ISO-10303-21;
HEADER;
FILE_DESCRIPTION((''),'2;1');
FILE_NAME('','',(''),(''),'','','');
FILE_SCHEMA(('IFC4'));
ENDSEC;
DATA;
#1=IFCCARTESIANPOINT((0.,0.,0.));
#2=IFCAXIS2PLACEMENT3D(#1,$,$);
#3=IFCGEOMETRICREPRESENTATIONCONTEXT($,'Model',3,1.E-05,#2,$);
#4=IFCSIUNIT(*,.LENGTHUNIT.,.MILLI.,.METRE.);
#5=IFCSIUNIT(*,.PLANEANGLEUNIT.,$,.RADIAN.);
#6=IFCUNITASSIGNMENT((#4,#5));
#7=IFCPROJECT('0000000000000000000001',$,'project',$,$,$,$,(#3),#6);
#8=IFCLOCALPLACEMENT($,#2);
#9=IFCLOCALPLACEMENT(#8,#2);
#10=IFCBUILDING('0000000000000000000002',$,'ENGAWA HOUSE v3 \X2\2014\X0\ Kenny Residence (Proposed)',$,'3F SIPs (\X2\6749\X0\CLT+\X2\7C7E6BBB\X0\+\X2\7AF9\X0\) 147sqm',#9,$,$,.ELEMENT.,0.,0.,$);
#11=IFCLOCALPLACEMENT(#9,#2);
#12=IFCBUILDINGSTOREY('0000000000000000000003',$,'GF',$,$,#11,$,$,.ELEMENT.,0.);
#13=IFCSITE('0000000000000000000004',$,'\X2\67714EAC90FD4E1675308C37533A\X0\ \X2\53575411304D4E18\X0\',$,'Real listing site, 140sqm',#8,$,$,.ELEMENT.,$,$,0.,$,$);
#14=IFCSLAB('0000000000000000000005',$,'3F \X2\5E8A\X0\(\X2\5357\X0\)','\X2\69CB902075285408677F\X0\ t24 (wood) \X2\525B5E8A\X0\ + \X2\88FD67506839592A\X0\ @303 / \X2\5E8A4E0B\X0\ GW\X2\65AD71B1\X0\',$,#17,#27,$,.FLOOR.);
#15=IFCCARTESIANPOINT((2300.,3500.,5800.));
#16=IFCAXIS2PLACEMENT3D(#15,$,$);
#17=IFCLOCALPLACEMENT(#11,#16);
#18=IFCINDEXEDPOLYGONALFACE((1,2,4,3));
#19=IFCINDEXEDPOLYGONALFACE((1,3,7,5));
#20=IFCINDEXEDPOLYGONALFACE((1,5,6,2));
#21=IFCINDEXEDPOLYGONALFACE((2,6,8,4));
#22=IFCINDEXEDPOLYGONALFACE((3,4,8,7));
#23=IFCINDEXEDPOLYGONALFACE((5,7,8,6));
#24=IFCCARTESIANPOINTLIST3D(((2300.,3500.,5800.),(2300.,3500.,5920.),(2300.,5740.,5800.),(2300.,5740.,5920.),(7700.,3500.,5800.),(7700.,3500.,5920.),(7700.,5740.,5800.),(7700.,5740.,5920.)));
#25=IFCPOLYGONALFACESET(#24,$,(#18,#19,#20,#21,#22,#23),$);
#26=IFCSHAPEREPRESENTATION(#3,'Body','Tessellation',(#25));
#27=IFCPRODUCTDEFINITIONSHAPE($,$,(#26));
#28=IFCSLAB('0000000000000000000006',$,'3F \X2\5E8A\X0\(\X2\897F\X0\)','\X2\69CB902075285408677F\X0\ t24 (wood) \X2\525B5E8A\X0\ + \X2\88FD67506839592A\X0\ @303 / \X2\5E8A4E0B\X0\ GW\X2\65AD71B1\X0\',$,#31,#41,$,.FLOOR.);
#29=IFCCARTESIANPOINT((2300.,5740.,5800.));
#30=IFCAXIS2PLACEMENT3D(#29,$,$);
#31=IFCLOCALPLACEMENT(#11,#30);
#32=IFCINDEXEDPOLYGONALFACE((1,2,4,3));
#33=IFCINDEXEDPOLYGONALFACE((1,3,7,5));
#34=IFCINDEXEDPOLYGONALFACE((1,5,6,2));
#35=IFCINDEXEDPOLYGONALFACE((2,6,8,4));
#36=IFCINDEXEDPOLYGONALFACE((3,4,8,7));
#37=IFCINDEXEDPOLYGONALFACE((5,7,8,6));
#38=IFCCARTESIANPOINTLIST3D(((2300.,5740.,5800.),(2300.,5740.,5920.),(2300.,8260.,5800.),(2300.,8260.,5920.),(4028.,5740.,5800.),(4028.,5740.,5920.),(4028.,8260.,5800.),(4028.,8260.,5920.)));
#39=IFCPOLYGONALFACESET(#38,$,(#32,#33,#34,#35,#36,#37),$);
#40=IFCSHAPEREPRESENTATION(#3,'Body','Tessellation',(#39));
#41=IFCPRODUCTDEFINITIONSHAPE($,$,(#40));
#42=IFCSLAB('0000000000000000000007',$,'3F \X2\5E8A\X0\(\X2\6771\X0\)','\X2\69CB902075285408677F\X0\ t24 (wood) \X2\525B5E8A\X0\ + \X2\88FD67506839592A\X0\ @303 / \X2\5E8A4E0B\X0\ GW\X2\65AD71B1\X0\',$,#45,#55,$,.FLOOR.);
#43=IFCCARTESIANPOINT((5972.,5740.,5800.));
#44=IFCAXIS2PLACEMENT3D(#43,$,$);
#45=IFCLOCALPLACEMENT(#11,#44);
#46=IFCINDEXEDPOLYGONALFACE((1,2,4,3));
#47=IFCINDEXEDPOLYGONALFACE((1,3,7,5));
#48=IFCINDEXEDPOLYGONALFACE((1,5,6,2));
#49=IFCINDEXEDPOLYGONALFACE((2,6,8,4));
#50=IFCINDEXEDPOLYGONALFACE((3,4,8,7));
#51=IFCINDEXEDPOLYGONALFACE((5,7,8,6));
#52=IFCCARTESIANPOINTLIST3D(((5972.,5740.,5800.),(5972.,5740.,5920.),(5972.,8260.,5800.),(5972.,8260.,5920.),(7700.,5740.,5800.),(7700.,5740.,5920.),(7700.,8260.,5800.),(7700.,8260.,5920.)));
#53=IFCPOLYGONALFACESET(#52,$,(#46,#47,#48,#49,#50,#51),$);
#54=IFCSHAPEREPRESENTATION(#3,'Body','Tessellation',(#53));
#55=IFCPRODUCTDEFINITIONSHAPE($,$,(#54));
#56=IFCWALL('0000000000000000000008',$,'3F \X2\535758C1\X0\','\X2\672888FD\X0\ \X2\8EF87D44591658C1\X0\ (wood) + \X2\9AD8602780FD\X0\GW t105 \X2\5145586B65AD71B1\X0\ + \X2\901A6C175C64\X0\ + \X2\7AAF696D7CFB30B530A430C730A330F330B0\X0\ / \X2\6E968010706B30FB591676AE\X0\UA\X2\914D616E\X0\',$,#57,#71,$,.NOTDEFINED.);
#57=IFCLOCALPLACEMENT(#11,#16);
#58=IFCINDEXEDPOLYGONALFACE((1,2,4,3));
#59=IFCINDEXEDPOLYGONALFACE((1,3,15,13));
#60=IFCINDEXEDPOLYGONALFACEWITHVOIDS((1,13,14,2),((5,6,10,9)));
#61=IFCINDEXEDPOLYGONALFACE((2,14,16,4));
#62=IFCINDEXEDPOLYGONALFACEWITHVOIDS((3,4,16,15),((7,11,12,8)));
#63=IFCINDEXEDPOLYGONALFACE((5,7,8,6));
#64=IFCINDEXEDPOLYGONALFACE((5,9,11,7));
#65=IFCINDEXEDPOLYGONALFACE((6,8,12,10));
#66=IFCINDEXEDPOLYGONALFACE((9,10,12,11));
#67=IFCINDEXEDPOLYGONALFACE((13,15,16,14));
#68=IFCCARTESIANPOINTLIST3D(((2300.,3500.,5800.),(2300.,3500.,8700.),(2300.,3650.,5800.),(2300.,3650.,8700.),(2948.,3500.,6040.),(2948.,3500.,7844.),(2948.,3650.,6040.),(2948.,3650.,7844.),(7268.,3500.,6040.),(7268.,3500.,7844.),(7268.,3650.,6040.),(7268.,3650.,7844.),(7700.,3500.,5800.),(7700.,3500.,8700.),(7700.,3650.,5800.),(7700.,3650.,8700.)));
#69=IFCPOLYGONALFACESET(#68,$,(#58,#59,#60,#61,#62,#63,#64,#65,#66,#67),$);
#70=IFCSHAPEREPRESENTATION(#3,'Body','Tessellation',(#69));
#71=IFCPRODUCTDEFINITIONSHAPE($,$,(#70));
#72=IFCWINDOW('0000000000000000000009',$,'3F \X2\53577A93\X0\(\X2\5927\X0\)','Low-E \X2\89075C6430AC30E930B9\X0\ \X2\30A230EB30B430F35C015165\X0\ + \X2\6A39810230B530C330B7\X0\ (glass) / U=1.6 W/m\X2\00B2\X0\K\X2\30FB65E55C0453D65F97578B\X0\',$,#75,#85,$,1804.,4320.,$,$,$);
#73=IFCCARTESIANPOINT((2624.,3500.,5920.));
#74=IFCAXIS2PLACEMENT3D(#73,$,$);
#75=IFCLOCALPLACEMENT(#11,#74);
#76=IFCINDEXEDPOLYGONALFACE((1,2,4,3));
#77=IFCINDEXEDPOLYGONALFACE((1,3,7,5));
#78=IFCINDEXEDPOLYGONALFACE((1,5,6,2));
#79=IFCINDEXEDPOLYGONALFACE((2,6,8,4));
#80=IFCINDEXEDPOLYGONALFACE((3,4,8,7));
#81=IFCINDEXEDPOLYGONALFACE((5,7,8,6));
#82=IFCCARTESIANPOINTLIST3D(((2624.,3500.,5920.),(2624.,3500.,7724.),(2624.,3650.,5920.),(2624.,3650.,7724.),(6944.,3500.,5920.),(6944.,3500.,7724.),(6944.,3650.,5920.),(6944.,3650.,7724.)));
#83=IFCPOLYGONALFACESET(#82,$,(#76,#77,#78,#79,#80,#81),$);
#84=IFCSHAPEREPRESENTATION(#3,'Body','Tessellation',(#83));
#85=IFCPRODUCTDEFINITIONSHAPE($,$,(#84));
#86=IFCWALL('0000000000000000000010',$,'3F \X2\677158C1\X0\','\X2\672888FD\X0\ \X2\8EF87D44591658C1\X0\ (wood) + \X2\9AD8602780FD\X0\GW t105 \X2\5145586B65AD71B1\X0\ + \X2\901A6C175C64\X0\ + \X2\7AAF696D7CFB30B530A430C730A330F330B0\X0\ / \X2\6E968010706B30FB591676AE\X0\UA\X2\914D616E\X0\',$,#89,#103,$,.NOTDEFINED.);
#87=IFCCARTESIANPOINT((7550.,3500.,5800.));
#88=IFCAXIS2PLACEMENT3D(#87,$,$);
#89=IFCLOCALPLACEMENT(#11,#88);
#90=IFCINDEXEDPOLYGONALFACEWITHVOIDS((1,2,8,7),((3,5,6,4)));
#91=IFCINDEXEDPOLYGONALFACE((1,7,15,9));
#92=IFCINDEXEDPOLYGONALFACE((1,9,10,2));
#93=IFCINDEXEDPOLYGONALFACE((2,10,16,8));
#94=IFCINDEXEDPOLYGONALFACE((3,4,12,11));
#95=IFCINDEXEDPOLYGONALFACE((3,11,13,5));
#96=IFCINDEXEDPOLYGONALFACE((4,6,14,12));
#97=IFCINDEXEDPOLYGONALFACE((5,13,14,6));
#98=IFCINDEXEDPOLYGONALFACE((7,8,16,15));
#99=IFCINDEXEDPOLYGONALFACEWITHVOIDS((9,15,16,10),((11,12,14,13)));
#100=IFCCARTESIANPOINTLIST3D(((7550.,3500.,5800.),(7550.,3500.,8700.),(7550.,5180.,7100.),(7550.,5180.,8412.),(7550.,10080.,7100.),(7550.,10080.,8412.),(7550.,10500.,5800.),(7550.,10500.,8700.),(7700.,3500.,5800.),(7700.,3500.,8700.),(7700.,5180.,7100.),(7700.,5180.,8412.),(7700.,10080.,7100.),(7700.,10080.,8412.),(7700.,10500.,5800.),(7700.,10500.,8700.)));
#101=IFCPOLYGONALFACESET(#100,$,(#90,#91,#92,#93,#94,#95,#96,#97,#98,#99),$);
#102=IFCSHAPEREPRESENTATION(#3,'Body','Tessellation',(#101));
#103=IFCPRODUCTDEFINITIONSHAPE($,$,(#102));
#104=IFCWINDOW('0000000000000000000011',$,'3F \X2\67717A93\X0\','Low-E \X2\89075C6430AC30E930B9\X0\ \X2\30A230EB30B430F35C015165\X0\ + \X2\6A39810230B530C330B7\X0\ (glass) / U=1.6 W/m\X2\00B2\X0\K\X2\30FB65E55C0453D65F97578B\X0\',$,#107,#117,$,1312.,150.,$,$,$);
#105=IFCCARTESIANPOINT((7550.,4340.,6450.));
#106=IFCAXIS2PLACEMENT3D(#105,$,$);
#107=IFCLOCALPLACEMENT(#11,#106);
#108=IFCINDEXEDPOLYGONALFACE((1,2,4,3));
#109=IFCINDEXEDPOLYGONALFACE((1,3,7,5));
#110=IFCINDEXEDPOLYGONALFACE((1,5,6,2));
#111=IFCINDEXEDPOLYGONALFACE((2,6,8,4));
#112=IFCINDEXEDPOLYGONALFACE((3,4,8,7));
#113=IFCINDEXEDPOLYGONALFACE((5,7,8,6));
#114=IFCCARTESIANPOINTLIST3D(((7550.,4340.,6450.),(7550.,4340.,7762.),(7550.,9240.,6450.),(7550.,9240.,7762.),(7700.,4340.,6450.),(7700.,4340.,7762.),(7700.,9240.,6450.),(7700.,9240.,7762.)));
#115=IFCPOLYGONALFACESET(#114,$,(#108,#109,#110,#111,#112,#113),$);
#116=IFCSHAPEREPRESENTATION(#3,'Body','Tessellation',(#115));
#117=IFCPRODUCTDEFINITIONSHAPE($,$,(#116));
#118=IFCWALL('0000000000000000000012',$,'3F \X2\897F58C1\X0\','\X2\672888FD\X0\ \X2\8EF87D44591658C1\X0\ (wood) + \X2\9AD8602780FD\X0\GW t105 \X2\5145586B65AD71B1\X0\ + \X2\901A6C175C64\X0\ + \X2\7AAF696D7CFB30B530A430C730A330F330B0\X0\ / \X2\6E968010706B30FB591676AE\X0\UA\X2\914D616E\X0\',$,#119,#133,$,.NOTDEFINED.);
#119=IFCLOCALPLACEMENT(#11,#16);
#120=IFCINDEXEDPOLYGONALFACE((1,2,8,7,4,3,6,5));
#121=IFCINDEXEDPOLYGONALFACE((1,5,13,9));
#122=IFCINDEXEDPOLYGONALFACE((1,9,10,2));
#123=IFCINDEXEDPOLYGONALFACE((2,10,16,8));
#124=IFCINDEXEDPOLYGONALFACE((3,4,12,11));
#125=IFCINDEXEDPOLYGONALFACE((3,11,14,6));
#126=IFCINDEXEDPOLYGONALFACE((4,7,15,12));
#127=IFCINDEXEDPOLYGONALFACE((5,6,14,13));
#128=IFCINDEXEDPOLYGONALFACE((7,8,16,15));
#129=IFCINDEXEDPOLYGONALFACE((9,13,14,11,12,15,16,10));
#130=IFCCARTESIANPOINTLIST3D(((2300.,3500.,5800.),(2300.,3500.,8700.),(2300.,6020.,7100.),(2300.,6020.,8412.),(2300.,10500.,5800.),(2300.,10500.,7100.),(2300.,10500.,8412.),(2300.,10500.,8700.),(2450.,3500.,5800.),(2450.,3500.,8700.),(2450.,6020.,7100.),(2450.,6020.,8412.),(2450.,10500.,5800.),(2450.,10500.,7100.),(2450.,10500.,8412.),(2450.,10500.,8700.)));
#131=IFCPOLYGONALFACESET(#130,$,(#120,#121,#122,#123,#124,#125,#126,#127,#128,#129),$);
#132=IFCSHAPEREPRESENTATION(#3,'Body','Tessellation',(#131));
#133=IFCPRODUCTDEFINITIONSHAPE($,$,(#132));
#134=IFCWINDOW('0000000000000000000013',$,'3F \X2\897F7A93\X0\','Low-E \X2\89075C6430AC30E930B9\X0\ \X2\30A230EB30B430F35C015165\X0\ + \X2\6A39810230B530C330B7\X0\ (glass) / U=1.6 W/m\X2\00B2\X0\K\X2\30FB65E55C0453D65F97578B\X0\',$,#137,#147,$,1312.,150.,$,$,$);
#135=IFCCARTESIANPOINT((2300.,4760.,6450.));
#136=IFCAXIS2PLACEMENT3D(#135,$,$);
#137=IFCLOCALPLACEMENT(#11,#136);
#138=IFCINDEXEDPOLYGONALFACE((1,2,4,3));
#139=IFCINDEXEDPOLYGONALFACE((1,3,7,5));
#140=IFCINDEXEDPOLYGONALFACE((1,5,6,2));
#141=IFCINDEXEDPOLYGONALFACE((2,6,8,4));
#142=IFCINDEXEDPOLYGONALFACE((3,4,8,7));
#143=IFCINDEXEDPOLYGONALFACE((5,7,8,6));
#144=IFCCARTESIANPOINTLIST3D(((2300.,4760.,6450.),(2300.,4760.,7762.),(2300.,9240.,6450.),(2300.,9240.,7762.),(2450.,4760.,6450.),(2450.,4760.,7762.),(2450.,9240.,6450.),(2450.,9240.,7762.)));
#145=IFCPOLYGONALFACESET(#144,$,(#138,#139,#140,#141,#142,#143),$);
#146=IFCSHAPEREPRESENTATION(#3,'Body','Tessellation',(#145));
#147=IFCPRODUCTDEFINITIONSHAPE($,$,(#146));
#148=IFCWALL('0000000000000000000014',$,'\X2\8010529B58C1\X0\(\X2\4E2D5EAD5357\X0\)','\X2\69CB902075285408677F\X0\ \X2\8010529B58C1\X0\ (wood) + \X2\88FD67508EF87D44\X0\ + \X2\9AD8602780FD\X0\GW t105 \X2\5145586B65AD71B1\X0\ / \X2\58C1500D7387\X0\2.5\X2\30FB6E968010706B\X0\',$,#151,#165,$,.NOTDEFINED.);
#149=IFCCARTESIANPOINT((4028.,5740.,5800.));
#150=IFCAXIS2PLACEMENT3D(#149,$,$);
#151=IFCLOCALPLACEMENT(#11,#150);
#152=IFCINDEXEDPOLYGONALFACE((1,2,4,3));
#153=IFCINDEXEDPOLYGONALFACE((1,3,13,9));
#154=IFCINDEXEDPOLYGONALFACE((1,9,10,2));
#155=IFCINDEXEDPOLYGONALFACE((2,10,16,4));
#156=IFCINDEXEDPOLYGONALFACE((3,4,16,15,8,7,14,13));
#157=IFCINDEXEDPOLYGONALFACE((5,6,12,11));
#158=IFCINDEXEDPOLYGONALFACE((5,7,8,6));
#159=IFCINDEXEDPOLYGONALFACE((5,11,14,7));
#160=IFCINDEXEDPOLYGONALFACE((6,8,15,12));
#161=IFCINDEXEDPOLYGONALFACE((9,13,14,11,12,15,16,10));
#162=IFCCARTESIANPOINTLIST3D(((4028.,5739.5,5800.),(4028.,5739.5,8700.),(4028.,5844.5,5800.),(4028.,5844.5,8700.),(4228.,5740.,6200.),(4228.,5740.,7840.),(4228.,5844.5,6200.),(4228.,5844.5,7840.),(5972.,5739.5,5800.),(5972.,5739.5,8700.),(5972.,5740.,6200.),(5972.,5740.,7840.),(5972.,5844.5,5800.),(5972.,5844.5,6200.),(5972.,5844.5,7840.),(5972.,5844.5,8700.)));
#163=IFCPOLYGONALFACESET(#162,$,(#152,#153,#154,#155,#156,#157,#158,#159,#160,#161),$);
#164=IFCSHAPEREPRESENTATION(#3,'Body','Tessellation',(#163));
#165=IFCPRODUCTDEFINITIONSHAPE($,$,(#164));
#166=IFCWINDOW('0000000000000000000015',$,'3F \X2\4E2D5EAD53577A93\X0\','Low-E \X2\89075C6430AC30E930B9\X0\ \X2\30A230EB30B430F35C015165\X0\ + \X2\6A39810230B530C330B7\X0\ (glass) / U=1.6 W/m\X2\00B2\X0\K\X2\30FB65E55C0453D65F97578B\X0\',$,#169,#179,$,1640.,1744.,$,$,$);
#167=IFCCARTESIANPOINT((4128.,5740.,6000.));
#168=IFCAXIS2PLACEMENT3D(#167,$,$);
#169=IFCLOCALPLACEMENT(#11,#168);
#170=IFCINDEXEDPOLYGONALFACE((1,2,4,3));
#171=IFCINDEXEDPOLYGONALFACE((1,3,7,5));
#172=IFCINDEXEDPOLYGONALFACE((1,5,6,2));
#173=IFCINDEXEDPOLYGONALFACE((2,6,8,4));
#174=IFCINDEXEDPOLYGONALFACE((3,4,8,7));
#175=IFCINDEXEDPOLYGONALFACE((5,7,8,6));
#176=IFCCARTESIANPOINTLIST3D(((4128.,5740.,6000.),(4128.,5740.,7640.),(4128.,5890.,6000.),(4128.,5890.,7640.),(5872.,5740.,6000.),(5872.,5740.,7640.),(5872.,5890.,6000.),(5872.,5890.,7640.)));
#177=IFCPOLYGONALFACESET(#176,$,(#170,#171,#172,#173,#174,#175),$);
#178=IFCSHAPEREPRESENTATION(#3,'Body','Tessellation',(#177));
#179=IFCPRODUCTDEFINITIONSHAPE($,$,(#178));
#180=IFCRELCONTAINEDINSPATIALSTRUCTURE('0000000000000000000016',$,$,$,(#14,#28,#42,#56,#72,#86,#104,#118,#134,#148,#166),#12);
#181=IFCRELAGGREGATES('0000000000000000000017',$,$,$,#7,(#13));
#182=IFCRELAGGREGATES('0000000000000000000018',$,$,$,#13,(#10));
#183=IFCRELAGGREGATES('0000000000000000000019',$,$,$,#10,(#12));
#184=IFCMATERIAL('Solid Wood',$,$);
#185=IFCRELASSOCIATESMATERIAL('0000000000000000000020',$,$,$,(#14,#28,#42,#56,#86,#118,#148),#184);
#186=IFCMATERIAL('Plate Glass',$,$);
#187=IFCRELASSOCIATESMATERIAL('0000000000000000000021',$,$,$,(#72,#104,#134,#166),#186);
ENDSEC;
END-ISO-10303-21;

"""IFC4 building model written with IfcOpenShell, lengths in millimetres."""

from ifc_helpers import new_model, si_unit, frame, frame_2d, origin, place, context, project, spatial, rectangle, extrude, material, element, fill, save


model = new_model("IFC4")

# Units and contexts
model_context = context("Model", 3, precision=1e-05, world=origin())
ifc_project = project(units=[si_unit("LENGTHUNIT", "METRE", prefix="MILLI"), si_unit("PLANEANGLEUNIT", "RADIAN")], contexts=[model_context])

# Site, building, storey
site_placement = place(None, origin())
site = spatial("IfcSite", under=ifc_project, at=site_placement, Name="東京都世田谷区 南向き丘", ObjectType="Real listing site, 140sqm", CompositionType="ELEMENT", RefElevation=0.0)
building_placement = place(site_placement, origin())
building = spatial("IfcBuilding", under=site, at=building_placement, Name="ENGAWA HOUSE v3 — Kenny Residence (Proposed)", ObjectType="3F SIPs (杉CLT+籾殻+竹) 147sqm", CompositionType="ELEMENT", ElevationOfRefHeight=0.0, ElevationOfTerrain=0.0)
storey_placement = place(building_placement, origin())
storey = spatial("IfcBuildingStorey", under=building, at=storey_placement, Name="GF", CompositionType="ELEMENT", Elevation=0.0)

# Slabs
ifc_material_1 = material(Name="Solid Wood")
slab_1_placement = place(storey_placement, frame((2300.0, 3500.0, 5800.0)))
element("IfcSlab", 1, at=slab_1_placement, inside=storey, material=ifc_material_1, Name="3F 床(南)", Description="構造用合板 t24 (wood) 剛床 + 製材根太 @303 / 床下 GW断熱", PredefinedType="FLOOR", context=model_context, shape_type="SweptSolid", body=[
    extrude(rectangle(XDim=5400.0, YDim=2240.0, at=frame_2d((2700.0, 1120.0))), frame((2300.0, 3500.0, 5800.0)), (0.0, 0.0, 1.0), 120.0),
])
slab_2_placement = place(storey_placement, frame((2300.0, 5740.0, 5800.0)))
element("IfcSlab", 2, at=slab_2_placement, inside=storey, material=ifc_material_1, Name="3F 床(西)", Description="構造用合板 t24 (wood) 剛床 + 製材根太 @303 / 床下 GW断熱", PredefinedType="FLOOR", context=model_context, shape_type="SweptSolid", body=[
    extrude(rectangle(XDim=1728.0, YDim=2520.0, at=frame_2d((864.0, 1260.0))), frame((2300.0, 5740.0, 5800.0)), (0.0, 0.0, 1.0), 120.0),
])
slab_3_placement = place(storey_placement, frame((5972.0, 5740.0, 5800.0)))
element("IfcSlab", 3, at=slab_3_placement, inside=storey, material=ifc_material_1, Name="3F 床(東)", Description="構造用合板 t24 (wood) 剛床 + 製材根太 @303 / 床下 GW断熱", PredefinedType="FLOOR", context=model_context, shape_type="SweptSolid", body=[
    extrude(rectangle(XDim=1728.0, YDim=2520.0, at=frame_2d((864.0, 1260.0))), frame((5972.0, 5740.0, 5800.0)), (0.0, 0.0, 1.0), 120.0),
])

# Walls, openings, windows
wall_1_placement = place(storey_placement, frame((2300.0, 3500.0, 5800.0)))
wall_1 = element("IfcWall", 4, at=wall_1_placement, inside=storey, material=ifc_material_1, Name="3F 南壁", Description="木製 軸組外壁 (wood) + 高性能GW t105 充填断熱 + 通気層 + 窯業系サイディング / 準耐火・外皮UA配慮", PredefinedType="NOTDEFINED", context=model_context, shape_type="SweptSolid", body=[
    extrude(rectangle(XDim=5400.0, YDim=150.0, at=frame_2d((2700.0, 75.0))), frame((2300.0, 3500.0, 5800.0)), (0.0, 0.0, 1.0), 2900.0),
])
opening_1_placement = place(storey_placement, frame((2624.0, 3500.0, 5920.0)))
opening_1 = element("IfcOpeningElement", 5, at=opening_1_placement, cuts=wall_1, PredefinedType="NOTDEFINED", context=model_context, shape_type="SweptSolid", body=[
    extrude(rectangle(XDim=4320.0, YDim=150.0, at=frame_2d((2160.0, 75.0))), frame((2624.0, 3500.0, 5920.0)), (0.0, 0.0, 1.0), 1804.0),
])
ifc_material_2 = material(Name="Plate Glass")
window_1_placement = place(storey_placement, frame((2624.0, 3500.0, 5920.0)))
window_1 = element("IfcWindow", 6, at=window_1_placement, inside=storey, material=ifc_material_2, Name="3F 南窓(大)", Description="Low-E 複層ガラス アルゴン封入 + 樹脂サッシ (glass) / U=1.6 W/m²K・日射取得型", OverallHeight=1804.0, OverallWidth=4320.0, context=model_context, shape_type="SweptSolid", body=[
    extrude(rectangle(XDim=4320.0, YDim=150.0, at=frame_2d((2160.0, 75.0))), frame((2624.0, 3500.0, 5920.0)), (0.0, 0.0, 1.0), 1804.0),
])
fill(opening_1, window_1)
wall_2_placement = place(storey_placement, frame((7550.0, 3500.0, 5800.0)))
wall_2 = element("IfcWall", 7, at=wall_2_placement, inside=storey, material=ifc_material_1, Name="3F 東壁", Description="木製 軸組外壁 (wood) + 高性能GW t105 充填断熱 + 通気層 + 窯業系サイディング / 準耐火・外皮UA配慮", PredefinedType="NOTDEFINED", context=model_context, shape_type="SweptSolid", body=[
    extrude(rectangle(XDim=150.0, YDim=7000.0, at=frame_2d((75.0, 3500.0))), frame((7550.0, 3500.0, 5800.0)), (0.0, 0.0, 1.0), 2900.0),
])
opening_2_placement = place(storey_placement, frame((7550.0, 4340.0, 6450.0)))
opening_2 = element("IfcOpeningElement", 8, at=opening_2_placement, cuts=wall_2, PredefinedType="NOTDEFINED", context=model_context, shape_type="SweptSolid", body=[
    extrude(rectangle(XDim=150.0, YDim=4900.0, at=frame_2d((75.0, 2450.0))), frame((7550.0, 4340.0, 6450.0)), (0.0, 0.0, 1.0), 1312.0),
])
window_2_placement = place(storey_placement, frame((7550.0, 4340.0, 6450.0)))
window_2 = element("IfcWindow", 9, at=window_2_placement, inside=storey, material=ifc_material_2, Name="3F 東窓", Description="Low-E 複層ガラス アルゴン封入 + 樹脂サッシ (glass) / U=1.6 W/m²K・日射取得型", OverallHeight=1312.0, OverallWidth=150.0, context=model_context, shape_type="SweptSolid", body=[
    extrude(rectangle(XDim=150.0, YDim=4900.0, at=frame_2d((75.0, 2450.0))), frame((7550.0, 4340.0, 6450.0)), (0.0, 0.0, 1.0), 1312.0),
])
fill(opening_2, window_2)
wall_3_placement = place(storey_placement, frame((2300.0, 3500.0, 5800.0)))
wall_3 = element("IfcWall", 10, at=wall_3_placement, inside=storey, material=ifc_material_1, Name="3F 西壁", Description="木製 軸組外壁 (wood) + 高性能GW t105 充填断熱 + 通気層 + 窯業系サイディング / 準耐火・外皮UA配慮", PredefinedType="NOTDEFINED", context=model_context, shape_type="SweptSolid", body=[
    extrude(rectangle(XDim=150.0, YDim=7000.0, at=frame_2d((75.0, 3500.0))), frame((2300.0, 3500.0, 5800.0)), (0.0, 0.0, 1.0), 2900.0),
])
opening_3_placement = place(storey_placement, frame((2300.0, 4760.0, 6450.0)))
opening_3 = element("IfcOpeningElement", 11, at=opening_3_placement, cuts=wall_3, PredefinedType="NOTDEFINED", context=model_context, shape_type="SweptSolid", body=[
    extrude(rectangle(XDim=150.0, YDim=4480.0, at=frame_2d((75.0, 2240.0))), frame((2300.0, 4760.0, 6450.0)), (0.0, 0.0, 1.0), 1312.0),
])
window_3_placement = place(storey_placement, frame((2300.0, 4760.0, 6450.0)))
window_3 = element("IfcWindow", 12, at=window_3_placement, inside=storey, material=ifc_material_2, Name="3F 西窓", Description="Low-E 複層ガラス アルゴン封入 + 樹脂サッシ (glass) / U=1.6 W/m²K・日射取得型", OverallHeight=1312.0, OverallWidth=150.0, context=model_context, shape_type="SweptSolid", body=[
    extrude(rectangle(XDim=150.0, YDim=4480.0, at=frame_2d((75.0, 2240.0))), frame((2300.0, 4760.0, 6450.0)), (0.0, 0.0, 1.0), 1312.0),
])
fill(opening_3, window_3)
wall_4_placement = place(storey_placement, frame((4028.0, 5740.0, 5800.0)))
wall_4 = element("IfcWall", 13, at=wall_4_placement, inside=storey, material=ifc_material_1, Name="耐力壁(中庭南)", Description="構造用合板 耐力壁 (wood) + 製材軸組 + 高性能GW t105 充填断熱 / 壁倍率2.5・準耐火", PredefinedType="NOTDEFINED", context=model_context, shape_type="SweptSolid", body=[
    extrude(rectangle(XDim=1944.0, YDim=105.0, at=frame_2d((972.0, 52.0))), frame((4028.0, 5740.0, 5800.0)), (0.0, 0.0, 1.0), 2900.0),
])
opening_4_placement = place(storey_placement, frame((4128.0, 5740.0, 6000.0)))
opening_4 = element("IfcOpeningElement", 14, at=opening_4_placement, cuts=wall_4, PredefinedType="NOTDEFINED", context=model_context, shape_type="SweptSolid", body=[
    extrude(rectangle(XDim=1744.0, YDim=150.0, at=frame_2d((872.0, 75.0))), frame((4128.0, 5740.0, 6000.0)), (0.0, 0.0, 1.0), 1640.0),
])
window_4_placement = place(storey_placement, frame((4128.0, 5740.0, 6000.0)))
window_4 = element("IfcWindow", 15, at=window_4_placement, inside=storey, material=ifc_material_2, Name="3F 中庭南窓", Description="Low-E 複層ガラス アルゴン封入 + 樹脂サッシ (glass) / U=1.6 W/m²K・日射取得型", OverallHeight=1640.0, OverallWidth=1744.0, context=model_context, shape_type="SweptSolid", body=[
    extrude(rectangle(XDim=1744.0, YDim=150.0, at=frame_2d((872.0, 75.0))), frame((4128.0, 5740.0, 6000.0)), (0.0, 0.0, 1.0), 1640.0),
])
fill(opening_4, window_4)

save(model, "model.ifc")
